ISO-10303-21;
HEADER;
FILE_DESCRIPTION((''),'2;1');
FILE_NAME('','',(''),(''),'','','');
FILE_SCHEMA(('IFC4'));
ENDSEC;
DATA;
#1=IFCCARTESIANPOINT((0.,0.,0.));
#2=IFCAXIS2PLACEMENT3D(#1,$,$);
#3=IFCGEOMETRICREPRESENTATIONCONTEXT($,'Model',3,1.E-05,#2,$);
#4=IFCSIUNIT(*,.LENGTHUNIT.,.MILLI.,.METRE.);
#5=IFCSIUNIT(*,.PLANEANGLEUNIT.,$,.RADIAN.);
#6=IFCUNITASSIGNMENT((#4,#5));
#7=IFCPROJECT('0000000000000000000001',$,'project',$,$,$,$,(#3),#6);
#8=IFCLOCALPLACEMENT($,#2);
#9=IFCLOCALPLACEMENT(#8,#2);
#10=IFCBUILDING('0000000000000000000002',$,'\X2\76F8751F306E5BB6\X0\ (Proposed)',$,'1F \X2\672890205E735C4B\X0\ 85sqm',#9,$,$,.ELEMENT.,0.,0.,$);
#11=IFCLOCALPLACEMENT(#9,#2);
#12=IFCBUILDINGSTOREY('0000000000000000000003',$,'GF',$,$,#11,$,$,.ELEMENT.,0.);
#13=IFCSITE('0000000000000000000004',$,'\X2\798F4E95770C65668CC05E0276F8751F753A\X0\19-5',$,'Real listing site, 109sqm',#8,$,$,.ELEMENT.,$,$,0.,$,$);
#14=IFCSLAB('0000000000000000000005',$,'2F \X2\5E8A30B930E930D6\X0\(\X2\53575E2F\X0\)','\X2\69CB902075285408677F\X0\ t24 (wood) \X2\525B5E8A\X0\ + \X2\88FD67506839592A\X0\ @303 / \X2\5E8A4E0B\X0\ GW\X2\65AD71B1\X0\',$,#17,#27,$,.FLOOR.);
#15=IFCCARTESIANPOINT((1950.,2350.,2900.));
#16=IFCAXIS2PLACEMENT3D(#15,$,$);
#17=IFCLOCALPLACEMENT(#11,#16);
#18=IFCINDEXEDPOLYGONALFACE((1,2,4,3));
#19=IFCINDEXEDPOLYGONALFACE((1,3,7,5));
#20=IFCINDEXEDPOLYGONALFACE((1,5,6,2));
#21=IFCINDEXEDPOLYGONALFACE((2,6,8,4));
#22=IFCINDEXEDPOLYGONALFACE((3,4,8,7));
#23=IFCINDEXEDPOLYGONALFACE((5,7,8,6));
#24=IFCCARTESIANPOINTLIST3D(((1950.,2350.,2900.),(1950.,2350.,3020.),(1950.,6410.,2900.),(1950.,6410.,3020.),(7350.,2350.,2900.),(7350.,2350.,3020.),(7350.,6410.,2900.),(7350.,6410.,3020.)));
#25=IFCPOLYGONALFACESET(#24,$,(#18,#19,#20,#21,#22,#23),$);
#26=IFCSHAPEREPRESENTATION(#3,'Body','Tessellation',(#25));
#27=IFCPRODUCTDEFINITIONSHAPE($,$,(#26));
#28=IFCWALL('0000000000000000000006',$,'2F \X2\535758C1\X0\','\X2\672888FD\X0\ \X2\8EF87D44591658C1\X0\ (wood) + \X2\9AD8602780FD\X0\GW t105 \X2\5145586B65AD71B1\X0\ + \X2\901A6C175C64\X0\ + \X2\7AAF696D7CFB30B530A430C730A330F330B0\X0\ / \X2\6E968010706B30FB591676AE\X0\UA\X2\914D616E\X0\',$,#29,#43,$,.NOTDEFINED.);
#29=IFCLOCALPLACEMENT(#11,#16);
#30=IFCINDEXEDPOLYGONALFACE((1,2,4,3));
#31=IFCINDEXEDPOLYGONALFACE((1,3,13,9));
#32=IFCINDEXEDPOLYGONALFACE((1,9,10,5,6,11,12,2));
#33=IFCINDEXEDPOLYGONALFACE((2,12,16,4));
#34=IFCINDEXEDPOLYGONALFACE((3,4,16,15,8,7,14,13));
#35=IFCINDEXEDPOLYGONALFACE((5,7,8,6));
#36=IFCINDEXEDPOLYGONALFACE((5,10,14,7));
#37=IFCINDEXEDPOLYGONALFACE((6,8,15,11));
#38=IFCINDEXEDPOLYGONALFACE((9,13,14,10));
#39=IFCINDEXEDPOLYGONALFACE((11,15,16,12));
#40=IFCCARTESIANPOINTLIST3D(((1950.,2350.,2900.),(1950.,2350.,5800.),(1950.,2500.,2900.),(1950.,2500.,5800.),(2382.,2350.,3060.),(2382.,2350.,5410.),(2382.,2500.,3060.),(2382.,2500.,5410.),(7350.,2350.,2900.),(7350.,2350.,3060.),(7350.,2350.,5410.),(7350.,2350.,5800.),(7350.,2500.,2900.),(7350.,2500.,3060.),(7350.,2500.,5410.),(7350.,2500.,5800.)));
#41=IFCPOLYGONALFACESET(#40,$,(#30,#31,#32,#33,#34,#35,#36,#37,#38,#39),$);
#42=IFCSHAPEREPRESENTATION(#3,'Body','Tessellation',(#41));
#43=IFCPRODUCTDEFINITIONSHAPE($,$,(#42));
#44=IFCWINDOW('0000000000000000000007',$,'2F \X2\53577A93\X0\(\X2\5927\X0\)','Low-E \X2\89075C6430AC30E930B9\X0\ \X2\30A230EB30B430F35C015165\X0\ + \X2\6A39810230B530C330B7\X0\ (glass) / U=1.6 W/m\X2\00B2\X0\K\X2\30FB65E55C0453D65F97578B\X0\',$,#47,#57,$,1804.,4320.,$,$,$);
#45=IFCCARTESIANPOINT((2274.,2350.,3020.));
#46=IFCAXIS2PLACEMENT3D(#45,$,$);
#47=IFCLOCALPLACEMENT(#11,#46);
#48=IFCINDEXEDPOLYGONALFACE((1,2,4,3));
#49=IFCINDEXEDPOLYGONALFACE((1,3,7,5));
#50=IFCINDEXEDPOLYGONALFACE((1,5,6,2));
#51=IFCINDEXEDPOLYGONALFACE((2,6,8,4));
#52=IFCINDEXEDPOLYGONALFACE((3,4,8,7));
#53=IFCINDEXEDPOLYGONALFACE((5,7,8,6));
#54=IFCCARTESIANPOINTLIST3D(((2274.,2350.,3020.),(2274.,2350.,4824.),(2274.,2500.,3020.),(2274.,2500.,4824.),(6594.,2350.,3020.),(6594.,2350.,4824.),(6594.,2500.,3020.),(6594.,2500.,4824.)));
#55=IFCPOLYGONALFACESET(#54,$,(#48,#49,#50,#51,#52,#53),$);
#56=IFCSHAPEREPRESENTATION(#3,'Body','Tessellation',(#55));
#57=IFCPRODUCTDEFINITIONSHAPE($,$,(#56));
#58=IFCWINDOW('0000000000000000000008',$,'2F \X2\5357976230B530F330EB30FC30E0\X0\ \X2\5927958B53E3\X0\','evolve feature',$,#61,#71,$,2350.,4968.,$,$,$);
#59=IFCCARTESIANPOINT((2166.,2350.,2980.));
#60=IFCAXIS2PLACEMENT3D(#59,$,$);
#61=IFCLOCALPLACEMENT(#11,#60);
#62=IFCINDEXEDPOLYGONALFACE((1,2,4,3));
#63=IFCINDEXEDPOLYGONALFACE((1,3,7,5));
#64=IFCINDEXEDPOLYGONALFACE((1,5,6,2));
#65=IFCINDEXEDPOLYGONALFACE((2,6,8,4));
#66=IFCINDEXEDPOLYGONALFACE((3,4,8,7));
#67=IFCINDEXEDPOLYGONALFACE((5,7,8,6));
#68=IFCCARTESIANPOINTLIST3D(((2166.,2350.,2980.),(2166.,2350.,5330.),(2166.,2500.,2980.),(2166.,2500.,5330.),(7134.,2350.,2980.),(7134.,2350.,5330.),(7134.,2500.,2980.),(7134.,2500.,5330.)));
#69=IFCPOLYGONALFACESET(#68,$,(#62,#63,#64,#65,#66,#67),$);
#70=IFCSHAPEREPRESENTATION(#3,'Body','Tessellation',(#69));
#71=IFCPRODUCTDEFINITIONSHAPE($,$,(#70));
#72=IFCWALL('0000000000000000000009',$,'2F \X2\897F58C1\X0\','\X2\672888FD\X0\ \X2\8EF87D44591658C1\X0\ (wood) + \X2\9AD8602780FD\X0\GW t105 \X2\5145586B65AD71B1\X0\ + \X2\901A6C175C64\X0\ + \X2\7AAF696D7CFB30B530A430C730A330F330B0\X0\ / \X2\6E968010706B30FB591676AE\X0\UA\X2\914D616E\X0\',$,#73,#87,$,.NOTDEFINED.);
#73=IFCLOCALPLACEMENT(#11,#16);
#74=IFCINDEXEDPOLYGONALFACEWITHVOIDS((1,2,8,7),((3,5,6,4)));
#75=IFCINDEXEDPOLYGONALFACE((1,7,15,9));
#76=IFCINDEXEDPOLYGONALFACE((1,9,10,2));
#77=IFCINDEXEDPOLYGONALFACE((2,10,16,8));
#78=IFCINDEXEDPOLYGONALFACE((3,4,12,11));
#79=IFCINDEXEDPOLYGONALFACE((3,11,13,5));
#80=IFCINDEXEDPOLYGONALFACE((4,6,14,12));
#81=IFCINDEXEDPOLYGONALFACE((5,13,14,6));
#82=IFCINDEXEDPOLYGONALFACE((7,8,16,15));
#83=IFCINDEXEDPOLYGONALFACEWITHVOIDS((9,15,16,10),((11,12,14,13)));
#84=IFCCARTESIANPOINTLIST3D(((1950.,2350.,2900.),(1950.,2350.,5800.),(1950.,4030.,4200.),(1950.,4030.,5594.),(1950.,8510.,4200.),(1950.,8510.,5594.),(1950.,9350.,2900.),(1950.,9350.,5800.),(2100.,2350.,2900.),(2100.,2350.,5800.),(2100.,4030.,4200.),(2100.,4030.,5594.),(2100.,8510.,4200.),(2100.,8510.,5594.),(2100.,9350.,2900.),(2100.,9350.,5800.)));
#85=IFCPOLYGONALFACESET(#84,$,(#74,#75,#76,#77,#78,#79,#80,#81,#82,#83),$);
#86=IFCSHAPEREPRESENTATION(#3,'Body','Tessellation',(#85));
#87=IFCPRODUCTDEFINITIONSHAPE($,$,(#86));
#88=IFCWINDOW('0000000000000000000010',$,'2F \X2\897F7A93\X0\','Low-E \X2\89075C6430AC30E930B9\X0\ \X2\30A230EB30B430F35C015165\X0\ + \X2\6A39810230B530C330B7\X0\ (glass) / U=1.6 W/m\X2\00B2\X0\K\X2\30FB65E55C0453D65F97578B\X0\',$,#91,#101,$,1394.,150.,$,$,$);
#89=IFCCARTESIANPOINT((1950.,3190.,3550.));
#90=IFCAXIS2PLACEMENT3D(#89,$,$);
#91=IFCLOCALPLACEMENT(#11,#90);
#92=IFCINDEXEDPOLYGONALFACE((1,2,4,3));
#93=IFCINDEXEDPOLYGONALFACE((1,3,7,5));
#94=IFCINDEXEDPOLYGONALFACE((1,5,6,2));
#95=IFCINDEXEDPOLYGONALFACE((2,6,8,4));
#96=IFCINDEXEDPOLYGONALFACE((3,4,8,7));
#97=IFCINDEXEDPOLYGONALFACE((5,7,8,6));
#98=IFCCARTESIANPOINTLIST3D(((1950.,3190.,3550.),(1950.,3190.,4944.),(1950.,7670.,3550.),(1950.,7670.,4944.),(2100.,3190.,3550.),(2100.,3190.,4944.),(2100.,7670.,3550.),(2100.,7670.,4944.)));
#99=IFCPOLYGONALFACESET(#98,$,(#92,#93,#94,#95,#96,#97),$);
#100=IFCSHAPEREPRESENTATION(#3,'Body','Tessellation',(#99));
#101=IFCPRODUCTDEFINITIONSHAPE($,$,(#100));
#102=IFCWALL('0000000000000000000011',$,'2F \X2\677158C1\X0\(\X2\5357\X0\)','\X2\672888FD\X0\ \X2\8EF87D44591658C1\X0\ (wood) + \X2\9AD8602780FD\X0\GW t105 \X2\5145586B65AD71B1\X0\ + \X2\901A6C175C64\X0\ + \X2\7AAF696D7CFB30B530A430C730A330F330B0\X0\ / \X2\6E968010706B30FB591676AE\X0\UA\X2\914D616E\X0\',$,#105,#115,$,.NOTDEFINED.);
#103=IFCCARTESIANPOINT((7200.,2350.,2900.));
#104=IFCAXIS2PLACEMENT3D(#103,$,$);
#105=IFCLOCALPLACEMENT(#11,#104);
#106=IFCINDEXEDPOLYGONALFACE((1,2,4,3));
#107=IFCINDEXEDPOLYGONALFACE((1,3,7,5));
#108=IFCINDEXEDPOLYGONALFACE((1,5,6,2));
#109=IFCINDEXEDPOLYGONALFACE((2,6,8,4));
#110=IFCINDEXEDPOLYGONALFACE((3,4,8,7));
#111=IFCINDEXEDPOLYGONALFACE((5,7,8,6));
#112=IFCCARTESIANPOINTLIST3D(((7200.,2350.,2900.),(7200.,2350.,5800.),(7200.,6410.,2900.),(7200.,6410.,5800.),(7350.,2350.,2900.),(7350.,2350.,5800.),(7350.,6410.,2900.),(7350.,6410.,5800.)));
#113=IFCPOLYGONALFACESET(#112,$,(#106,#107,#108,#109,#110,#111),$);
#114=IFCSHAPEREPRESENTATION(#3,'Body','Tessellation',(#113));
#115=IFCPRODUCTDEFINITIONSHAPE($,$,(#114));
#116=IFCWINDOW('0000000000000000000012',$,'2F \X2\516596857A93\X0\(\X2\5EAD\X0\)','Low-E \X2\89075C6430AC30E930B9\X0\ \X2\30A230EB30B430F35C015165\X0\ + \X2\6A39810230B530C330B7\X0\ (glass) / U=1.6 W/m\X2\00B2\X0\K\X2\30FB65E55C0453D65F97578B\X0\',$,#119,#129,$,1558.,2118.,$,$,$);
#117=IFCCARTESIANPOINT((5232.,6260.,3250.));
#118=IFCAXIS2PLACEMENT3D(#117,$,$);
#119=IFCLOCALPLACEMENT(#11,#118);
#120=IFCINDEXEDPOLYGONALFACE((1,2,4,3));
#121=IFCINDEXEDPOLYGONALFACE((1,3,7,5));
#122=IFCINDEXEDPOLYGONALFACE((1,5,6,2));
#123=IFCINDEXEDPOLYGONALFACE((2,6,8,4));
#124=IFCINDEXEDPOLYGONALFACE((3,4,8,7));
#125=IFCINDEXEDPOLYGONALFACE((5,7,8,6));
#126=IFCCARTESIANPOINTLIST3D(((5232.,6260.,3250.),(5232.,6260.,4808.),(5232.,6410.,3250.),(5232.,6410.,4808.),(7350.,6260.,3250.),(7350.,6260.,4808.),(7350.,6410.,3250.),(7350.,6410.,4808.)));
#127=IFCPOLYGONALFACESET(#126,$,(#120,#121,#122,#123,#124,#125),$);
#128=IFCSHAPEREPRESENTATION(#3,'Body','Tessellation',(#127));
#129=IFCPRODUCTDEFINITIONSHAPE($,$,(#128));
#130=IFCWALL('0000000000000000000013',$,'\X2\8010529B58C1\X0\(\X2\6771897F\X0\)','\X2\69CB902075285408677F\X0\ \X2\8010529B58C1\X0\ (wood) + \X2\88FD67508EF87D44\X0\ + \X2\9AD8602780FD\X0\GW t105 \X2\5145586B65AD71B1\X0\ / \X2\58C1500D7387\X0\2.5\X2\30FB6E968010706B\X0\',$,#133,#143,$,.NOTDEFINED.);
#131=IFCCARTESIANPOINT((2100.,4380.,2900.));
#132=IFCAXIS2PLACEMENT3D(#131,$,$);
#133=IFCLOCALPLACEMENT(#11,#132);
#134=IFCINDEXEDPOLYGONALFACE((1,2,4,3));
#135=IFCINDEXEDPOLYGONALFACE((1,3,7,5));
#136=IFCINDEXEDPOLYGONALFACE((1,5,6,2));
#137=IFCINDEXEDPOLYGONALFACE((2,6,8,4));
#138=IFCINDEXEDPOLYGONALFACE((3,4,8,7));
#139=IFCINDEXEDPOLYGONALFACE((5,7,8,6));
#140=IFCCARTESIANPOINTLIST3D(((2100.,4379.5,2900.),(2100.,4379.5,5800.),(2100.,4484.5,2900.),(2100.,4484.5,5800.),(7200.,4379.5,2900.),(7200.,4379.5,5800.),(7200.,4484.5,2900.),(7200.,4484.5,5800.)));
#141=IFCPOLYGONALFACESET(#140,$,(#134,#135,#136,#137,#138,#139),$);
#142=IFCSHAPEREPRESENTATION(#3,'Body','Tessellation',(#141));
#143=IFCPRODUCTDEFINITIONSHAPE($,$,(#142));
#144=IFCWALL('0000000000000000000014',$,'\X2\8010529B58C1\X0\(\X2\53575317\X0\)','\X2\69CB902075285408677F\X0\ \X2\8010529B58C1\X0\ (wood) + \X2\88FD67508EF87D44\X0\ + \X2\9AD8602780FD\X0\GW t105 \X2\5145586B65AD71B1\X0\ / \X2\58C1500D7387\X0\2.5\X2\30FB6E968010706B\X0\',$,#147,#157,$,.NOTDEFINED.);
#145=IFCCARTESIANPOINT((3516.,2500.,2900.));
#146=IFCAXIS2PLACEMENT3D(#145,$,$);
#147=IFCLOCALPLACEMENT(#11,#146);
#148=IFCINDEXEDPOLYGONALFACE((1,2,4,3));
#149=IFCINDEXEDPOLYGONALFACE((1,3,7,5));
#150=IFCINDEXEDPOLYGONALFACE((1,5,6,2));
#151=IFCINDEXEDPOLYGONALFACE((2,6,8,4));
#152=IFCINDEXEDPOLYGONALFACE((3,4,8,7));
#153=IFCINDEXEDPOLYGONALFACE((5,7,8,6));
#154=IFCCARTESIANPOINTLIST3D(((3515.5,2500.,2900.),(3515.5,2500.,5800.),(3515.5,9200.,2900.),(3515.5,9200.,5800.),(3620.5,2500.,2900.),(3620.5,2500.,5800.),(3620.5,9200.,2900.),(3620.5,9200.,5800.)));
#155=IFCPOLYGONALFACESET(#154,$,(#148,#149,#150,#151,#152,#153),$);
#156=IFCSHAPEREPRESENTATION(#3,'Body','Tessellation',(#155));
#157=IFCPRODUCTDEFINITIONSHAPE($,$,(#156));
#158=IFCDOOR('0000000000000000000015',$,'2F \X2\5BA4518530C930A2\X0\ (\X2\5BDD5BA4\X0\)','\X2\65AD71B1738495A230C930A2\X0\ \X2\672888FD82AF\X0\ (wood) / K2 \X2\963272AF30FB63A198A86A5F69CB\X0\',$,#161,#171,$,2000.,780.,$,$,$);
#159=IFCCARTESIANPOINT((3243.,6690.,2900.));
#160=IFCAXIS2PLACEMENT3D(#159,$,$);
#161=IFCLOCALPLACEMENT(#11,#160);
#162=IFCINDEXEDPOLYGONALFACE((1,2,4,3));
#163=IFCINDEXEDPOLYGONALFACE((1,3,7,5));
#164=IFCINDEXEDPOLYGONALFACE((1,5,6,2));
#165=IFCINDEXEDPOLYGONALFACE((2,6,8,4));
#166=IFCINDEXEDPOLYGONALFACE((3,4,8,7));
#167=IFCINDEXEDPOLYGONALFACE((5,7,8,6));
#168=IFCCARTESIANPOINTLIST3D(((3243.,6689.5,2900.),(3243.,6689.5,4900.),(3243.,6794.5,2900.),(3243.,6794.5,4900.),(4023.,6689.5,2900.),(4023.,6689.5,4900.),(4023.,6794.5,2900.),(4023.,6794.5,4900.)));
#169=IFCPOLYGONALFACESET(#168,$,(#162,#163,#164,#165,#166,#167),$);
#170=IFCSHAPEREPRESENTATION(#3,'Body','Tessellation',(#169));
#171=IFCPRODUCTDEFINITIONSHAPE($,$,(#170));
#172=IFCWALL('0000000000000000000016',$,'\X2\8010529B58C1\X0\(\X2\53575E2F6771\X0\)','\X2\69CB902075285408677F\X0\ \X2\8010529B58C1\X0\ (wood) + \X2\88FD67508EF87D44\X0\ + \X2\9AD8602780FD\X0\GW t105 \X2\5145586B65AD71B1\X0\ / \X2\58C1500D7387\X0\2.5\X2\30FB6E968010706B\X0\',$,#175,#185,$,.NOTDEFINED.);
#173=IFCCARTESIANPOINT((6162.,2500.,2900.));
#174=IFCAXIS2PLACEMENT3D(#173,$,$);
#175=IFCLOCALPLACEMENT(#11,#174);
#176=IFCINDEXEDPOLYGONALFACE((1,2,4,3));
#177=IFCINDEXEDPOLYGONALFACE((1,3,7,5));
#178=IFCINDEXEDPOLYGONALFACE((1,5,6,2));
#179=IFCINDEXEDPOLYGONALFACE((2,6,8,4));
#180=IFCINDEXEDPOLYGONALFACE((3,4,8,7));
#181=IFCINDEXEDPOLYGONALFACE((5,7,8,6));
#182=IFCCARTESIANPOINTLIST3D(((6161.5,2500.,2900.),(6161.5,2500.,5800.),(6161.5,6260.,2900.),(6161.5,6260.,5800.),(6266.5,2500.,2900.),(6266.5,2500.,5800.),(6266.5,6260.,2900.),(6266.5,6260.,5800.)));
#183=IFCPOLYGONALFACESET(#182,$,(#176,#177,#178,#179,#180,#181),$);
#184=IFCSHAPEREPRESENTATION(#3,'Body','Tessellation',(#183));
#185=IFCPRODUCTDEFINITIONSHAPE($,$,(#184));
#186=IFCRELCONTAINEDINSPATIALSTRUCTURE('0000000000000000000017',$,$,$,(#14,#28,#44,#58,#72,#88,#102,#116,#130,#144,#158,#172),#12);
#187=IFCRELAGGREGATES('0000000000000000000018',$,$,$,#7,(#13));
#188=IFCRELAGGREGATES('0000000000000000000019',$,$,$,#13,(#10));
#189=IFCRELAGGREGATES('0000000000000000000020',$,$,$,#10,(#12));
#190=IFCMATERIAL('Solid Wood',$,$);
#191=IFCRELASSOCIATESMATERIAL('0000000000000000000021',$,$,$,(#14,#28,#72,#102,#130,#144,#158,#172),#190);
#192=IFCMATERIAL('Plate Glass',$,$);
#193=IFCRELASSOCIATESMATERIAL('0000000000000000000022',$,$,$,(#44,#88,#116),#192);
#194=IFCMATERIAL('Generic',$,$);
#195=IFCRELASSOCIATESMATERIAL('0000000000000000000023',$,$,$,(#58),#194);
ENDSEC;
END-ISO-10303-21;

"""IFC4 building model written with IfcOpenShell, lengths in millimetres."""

from ifc_helpers import new_model, si_unit, frame, frame_2d, origin, place, context, project, spatial, rectangle, extrude, material, element, fill, save


model = new_model("IFC4")

# Units and contexts
model_context = context("Model", 3, precision=1e-05, world=origin())
ifc_project = project(units=[si_unit("LENGTHUNIT", "METRE", prefix="MILLI"), si_unit("PLANEANGLEUNIT", "RADIAN")], contexts=[model_context])

# Site, building, storey
site_placement = place(None, origin())
site = spatial("IfcSite", under=ifc_project, at=site_placement, Name="福井県敦賀市相生町19-5", ObjectType="Real listing site, 109sqm", CompositionType="ELEMENT", RefElevation=0.0)
building_placement = place(site_placement, origin())
building = spatial("IfcBuilding", under=site, at=building_placement, Name="相生の家 (Proposed)", ObjectType="1F 木造平屋 85sqm", CompositionType="ELEMENT", ElevationOfRefHeight=0.0, ElevationOfTerrain=0.0)
storey_placement = place(building_placement, origin())
storey = spatial("IfcBuildingStorey", under=building, at=storey_placement, Name="GF", CompositionType="ELEMENT", Elevation=0.0)

# Slab
ifc_material_1 = material(Name="Solid Wood")
slab_placement = place(storey_placement, frame((1950.0, 2350.0, 2900.0)))
element("IfcSlab", 1, at=slab_placement, inside=storey, material=ifc_material_1, Name="2F 床スラブ(南帯)", Description="構造用合板 t24 (wood) 剛床 + 製材根太 @303 / 床下 GW断熱", PredefinedType="FLOOR", context=model_context, shape_type="SweptSolid", body=[
    extrude(rectangle(XDim=5400.0, YDim=4060.0, at=frame_2d((2700.0, 2030.0))), frame((1950.0, 2350.0, 2900.0)), (0.0, 0.0, 1.0), 120.0),
])

# Wall, openings, windows
wall_1_placement = place(storey_placement, frame((1950.0, 2350.0, 2900.0)))
wall_1 = element("IfcWall", 2, at=wall_1_placement, inside=storey, material=ifc_material_1, Name="2F 南壁", Description="木製 軸組外壁 (wood) + 高性能GW t105 充填断熱 + 通気層 + 窯業系サイディング / 準耐火・外皮UA配慮", PredefinedType="NOTDEFINED", context=model_context, shape_type="SweptSolid", body=[
    extrude(rectangle(XDim=5400.0, YDim=150.0, at=frame_2d((2700.0, 75.0))), frame((1950.0, 2350.0, 2900.0)), (0.0, 0.0, 1.0), 2900.0),
])
opening_1_placement = place(storey_placement, frame((2274.0, 2350.0, 3020.0)))
opening_1 = element("IfcOpeningElement", 3, at=opening_1_placement, cuts=wall_1, PredefinedType="NOTDEFINED", context=model_context, shape_type="SweptSolid", body=[
    extrude(rectangle(XDim=4320.0, YDim=150.0, at=frame_2d((2160.0, 75.0))), frame((2274.0, 2350.0, 3020.0)), (0.0, 0.0, 1.0), 1804.0),
])
opening_2_placement = place(storey_placement, frame((2166.0, 2350.0, 2980.0)))
opening_2 = element("IfcOpeningElement", 4, at=opening_2_placement, cuts=wall_1, PredefinedType="NOTDEFINED", context=model_context, shape_type="SweptSolid", body=[
    extrude(rectangle(XDim=4968.0, YDim=150.0, at=frame_2d((2484.0, 75.0))), frame((2166.0, 2350.0, 2980.0)), (0.0, 0.0, 1.0), 2350.0),
])
ifc_material_2 = material(Name="Plate Glass")
window_1_placement = place(storey_placement, frame((2274.0, 2350.0, 3020.0)))
window_1 = element("IfcWindow", 5, at=window_1_placement, inside=storey, material=ifc_material_2, Name="2F 南窓(大)", Description="Low-E 複層ガラス アルゴン封入 + 樹脂サッシ (glass) / U=1.6 W/m²K・日射取得型", OverallHeight=1804.0, OverallWidth=4320.0, context=model_context, shape_type="SweptSolid", body=[
    extrude(rectangle(XDim=4320.0, YDim=150.0, at=frame_2d((2160.0, 75.0))), frame((2274.0, 2350.0, 3020.0)), (0.0, 0.0, 1.0), 1804.0),
])
fill(opening_1, window_1)
ifc_material_3 = material(Name="Generic")
window_2_placement = place(storey_placement, frame((2166.0, 2350.0, 2980.0)))
window_2 = element("IfcWindow", 6, at=window_2_placement, inside=storey, material=ifc_material_3, Name="2F 南面サンルーム 大開口", Description="evolve feature", OverallHeight=2350.0, OverallWidth=4968.0, context=model_context, shape_type="SweptSolid", body=[
    extrude(rectangle(XDim=4968.0, YDim=150.0, at=frame_2d((2484.0, 75.0))), frame((2166.0, 2350.0, 2980.0)), (0.0, 0.0, 1.0), 2350.0),
])
fill(opening_2, window_2)

# Walls, openings, windows
wall_2_placement = place(storey_placement, frame((1950.0, 2350.0, 2900.0)))
wall_2 = element("IfcWall", 7, at=wall_2_placement, inside=storey, material=ifc_material_1, Name="2F 西壁", Description="木製 軸組外壁 (wood) + 高性能GW t105 充填断熱 + 通気層 + 窯業系サイディング / 準耐火・外皮UA配慮", PredefinedType="NOTDEFINED", context=model_context, shape_type="SweptSolid", body=[
    extrude(rectangle(XDim=150.0, YDim=7000.0, at=frame_2d((75.0, 3500.0))), frame((1950.0, 2350.0, 2900.0)), (0.0, 0.0, 1.0), 2900.0),
])
opening_3_placement = place(storey_placement, frame((1950.0, 3190.0, 3550.0)))
opening_3 = element("IfcOpeningElement", 8, at=opening_3_placement, cuts=wall_2, PredefinedType="NOTDEFINED", context=model_context, shape_type="SweptSolid", body=[
    extrude(rectangle(XDim=150.0, YDim=4480.0, at=frame_2d((75.0, 2240.0))), frame((1950.0, 3190.0, 3550.0)), (0.0, 0.0, 1.0), 1394.0),
])
window_3_placement = place(storey_placement, frame((1950.0, 3190.0, 3550.0)))
window_3 = element("IfcWindow", 9, at=window_3_placement, inside=storey, material=ifc_material_2, Name="2F 西窓", Description="Low-E 複層ガラス アルゴン封入 + 樹脂サッシ (glass) / U=1.6 W/m²K・日射取得型", OverallHeight=1394.0, OverallWidth=150.0, context=model_context, shape_type="SweptSolid", body=[
    extrude(rectangle(XDim=150.0, YDim=4480.0, at=frame_2d((75.0, 2240.0))), frame((1950.0, 3190.0, 3550.0)), (0.0, 0.0, 1.0), 1394.0),
])
fill(opening_3, window_3)
wall_3_placement = place(storey_placement, frame((7200.0, 2350.0, 2900.0)))
wall_3 = element("IfcWall", 10, at=wall_3_placement, inside=storey, material=ifc_material_1, Name="2F 東壁(南)", Description="木製 軸組外壁 (wood) + 高性能GW t105 充填断熱 + 通気層 + 窯業系サイディング / 準耐火・外皮UA配慮", PredefinedType="NOTDEFINED", context=model_context, shape_type="SweptSolid", body=[
    extrude(rectangle(XDim=150.0, YDim=4060.0, at=frame_2d((75.0, 2030.0))), frame((7200.0, 2350.0, 2900.0)), (0.0, 0.0, 1.0), 2900.0),
])
opening_4_placement = place(storey_placement, frame((5232.0, 6260.0, 3250.0)))
opening_4 = element("IfcOpeningElement", 11, at=opening_4_placement, cuts=wall_3, PredefinedType="NOTDEFINED", context=model_context, shape_type="SweptSolid", body=[
    extrude(rectangle(XDim=2118.0, YDim=150.0, at=frame_2d((1059.0, 75.0))), frame((5232.0, 6260.0, 3250.0)), (0.0, 0.0, 1.0), 1558.0),
])
window_4_placement = place(storey_placement, frame((5232.0, 6260.0, 3250.0)))
window_4 = element("IfcWindow", 12, at=window_4_placement, inside=storey, material=ifc_material_2, Name="2F 入隅窓(庭)", Description="Low-E 複層ガラス アルゴン封入 + 樹脂サッシ (glass) / U=1.6 W/m²K・日射取得型", OverallHeight=1558.0, OverallWidth=2118.0, context=model_context, shape_type="SweptSolid", body=[
    extrude(rectangle(XDim=2118.0, YDim=150.0, at=frame_2d((1059.0, 75.0))), frame((5232.0, 6260.0, 3250.0)), (0.0, 0.0, 1.0), 1558.0),
])
fill(opening_4, window_4)

# Wall
wall_4_placement = place(storey_placement, frame((2100.0, 4380.0, 2900.0)))
element("IfcWall", 13, at=wall_4_placement, inside=storey, material=ifc_material_1, Name="耐力壁(東西)", Description="構造用合板 耐力壁 (wood) + 製材軸組 + 高性能GW t105 充填断熱 / 壁倍率2.5・準耐火", PredefinedType="NOTDEFINED", context=model_context, shape_type="SweptSolid", body=[
    extrude(rectangle(XDim=5100.0, YDim=105.0, at=frame_2d((2550.0, 52.0))), frame((2100.0, 4380.0, 2900.0)), (0.0, 0.0, 1.0), 2900.0),
])

# Wall, opening, door
wall_5_placement = place(storey_placement, frame((3516.0, 2500.0, 2900.0)))
wall_5 = element("IfcWall", 14, at=wall_5_placement, inside=storey, material=ifc_material_1, Name="耐力壁(南北)", Description="構造用合板 耐力壁 (wood) + 製材軸組 + 高性能GW t105 充填断熱 / 壁倍率2.5・準耐火", PredefinedType="NOTDEFINED", context=model_context, shape_type="SweptSolid", body=[
    extrude(rectangle(XDim=105.0, YDim=6700.0, at=frame_2d((52.0, 3350.0))), frame((3516.0, 2500.0, 2900.0)), (0.0, 0.0, 1.0), 2900.0),
])
opening_5_placement = place(storey_placement, frame((3243.0, 6690.0, 2900.0)))
opening_5 = element("IfcOpeningElement", 15, at=opening_5_placement, cuts=wall_5, PredefinedType="NOTDEFINED", context=model_context, shape_type="SweptSolid", body=[
    extrude(rectangle(XDim=780.0, YDim=105.0, at=frame_2d((390.0, 52.0))), frame((3243.0, 6690.0, 2900.0)), (0.0, 0.0, 1.0), 2000.0),
])
door_placement = place(storey_placement, frame((3243.0, 6690.0, 2900.0)))
door = element("IfcDoor", 16, at=door_placement, inside=storey, material=ifc_material_1, Name="2F 室内ドア (寝室)", Description="断熱玄関ドア 木製芯 (wood) / K2 防犯・採風機構", OverallHeight=2000.0, OverallWidth=780.0, context=model_context, shape_type="SweptSolid", body=[
    extrude(rectangle(XDim=780.0, YDim=105.0, at=frame_2d((390.0, 52.0))), frame((3243.0, 6690.0, 2900.0)), (0.0, 0.0, 1.0), 2000.0),
])
fill(opening_5, door)

# Wall
wall_6_placement = place(storey_placement, frame((6162.0, 2500.0, 2900.0)))
element("IfcWall", 17, at=wall_6_placement, inside=storey, material=ifc_material_1, Name="耐力壁(南帯東)", Description="構造用合板 耐力壁 (wood) + 製材軸組 + 高性能GW t105 充填断熱 / 壁倍率2.5・準耐火", PredefinedType="NOTDEFINED", context=model_context, shape_type="SweptSolid", body=[
    extrude(rectangle(XDim=105.0, YDim=3760.0, at=frame_2d((52.0, 1880.0))), frame((6162.0, 2500.0, 2900.0)), (0.0, 0.0, 1.0), 2900.0),
])

save(model, "model.ifc")
